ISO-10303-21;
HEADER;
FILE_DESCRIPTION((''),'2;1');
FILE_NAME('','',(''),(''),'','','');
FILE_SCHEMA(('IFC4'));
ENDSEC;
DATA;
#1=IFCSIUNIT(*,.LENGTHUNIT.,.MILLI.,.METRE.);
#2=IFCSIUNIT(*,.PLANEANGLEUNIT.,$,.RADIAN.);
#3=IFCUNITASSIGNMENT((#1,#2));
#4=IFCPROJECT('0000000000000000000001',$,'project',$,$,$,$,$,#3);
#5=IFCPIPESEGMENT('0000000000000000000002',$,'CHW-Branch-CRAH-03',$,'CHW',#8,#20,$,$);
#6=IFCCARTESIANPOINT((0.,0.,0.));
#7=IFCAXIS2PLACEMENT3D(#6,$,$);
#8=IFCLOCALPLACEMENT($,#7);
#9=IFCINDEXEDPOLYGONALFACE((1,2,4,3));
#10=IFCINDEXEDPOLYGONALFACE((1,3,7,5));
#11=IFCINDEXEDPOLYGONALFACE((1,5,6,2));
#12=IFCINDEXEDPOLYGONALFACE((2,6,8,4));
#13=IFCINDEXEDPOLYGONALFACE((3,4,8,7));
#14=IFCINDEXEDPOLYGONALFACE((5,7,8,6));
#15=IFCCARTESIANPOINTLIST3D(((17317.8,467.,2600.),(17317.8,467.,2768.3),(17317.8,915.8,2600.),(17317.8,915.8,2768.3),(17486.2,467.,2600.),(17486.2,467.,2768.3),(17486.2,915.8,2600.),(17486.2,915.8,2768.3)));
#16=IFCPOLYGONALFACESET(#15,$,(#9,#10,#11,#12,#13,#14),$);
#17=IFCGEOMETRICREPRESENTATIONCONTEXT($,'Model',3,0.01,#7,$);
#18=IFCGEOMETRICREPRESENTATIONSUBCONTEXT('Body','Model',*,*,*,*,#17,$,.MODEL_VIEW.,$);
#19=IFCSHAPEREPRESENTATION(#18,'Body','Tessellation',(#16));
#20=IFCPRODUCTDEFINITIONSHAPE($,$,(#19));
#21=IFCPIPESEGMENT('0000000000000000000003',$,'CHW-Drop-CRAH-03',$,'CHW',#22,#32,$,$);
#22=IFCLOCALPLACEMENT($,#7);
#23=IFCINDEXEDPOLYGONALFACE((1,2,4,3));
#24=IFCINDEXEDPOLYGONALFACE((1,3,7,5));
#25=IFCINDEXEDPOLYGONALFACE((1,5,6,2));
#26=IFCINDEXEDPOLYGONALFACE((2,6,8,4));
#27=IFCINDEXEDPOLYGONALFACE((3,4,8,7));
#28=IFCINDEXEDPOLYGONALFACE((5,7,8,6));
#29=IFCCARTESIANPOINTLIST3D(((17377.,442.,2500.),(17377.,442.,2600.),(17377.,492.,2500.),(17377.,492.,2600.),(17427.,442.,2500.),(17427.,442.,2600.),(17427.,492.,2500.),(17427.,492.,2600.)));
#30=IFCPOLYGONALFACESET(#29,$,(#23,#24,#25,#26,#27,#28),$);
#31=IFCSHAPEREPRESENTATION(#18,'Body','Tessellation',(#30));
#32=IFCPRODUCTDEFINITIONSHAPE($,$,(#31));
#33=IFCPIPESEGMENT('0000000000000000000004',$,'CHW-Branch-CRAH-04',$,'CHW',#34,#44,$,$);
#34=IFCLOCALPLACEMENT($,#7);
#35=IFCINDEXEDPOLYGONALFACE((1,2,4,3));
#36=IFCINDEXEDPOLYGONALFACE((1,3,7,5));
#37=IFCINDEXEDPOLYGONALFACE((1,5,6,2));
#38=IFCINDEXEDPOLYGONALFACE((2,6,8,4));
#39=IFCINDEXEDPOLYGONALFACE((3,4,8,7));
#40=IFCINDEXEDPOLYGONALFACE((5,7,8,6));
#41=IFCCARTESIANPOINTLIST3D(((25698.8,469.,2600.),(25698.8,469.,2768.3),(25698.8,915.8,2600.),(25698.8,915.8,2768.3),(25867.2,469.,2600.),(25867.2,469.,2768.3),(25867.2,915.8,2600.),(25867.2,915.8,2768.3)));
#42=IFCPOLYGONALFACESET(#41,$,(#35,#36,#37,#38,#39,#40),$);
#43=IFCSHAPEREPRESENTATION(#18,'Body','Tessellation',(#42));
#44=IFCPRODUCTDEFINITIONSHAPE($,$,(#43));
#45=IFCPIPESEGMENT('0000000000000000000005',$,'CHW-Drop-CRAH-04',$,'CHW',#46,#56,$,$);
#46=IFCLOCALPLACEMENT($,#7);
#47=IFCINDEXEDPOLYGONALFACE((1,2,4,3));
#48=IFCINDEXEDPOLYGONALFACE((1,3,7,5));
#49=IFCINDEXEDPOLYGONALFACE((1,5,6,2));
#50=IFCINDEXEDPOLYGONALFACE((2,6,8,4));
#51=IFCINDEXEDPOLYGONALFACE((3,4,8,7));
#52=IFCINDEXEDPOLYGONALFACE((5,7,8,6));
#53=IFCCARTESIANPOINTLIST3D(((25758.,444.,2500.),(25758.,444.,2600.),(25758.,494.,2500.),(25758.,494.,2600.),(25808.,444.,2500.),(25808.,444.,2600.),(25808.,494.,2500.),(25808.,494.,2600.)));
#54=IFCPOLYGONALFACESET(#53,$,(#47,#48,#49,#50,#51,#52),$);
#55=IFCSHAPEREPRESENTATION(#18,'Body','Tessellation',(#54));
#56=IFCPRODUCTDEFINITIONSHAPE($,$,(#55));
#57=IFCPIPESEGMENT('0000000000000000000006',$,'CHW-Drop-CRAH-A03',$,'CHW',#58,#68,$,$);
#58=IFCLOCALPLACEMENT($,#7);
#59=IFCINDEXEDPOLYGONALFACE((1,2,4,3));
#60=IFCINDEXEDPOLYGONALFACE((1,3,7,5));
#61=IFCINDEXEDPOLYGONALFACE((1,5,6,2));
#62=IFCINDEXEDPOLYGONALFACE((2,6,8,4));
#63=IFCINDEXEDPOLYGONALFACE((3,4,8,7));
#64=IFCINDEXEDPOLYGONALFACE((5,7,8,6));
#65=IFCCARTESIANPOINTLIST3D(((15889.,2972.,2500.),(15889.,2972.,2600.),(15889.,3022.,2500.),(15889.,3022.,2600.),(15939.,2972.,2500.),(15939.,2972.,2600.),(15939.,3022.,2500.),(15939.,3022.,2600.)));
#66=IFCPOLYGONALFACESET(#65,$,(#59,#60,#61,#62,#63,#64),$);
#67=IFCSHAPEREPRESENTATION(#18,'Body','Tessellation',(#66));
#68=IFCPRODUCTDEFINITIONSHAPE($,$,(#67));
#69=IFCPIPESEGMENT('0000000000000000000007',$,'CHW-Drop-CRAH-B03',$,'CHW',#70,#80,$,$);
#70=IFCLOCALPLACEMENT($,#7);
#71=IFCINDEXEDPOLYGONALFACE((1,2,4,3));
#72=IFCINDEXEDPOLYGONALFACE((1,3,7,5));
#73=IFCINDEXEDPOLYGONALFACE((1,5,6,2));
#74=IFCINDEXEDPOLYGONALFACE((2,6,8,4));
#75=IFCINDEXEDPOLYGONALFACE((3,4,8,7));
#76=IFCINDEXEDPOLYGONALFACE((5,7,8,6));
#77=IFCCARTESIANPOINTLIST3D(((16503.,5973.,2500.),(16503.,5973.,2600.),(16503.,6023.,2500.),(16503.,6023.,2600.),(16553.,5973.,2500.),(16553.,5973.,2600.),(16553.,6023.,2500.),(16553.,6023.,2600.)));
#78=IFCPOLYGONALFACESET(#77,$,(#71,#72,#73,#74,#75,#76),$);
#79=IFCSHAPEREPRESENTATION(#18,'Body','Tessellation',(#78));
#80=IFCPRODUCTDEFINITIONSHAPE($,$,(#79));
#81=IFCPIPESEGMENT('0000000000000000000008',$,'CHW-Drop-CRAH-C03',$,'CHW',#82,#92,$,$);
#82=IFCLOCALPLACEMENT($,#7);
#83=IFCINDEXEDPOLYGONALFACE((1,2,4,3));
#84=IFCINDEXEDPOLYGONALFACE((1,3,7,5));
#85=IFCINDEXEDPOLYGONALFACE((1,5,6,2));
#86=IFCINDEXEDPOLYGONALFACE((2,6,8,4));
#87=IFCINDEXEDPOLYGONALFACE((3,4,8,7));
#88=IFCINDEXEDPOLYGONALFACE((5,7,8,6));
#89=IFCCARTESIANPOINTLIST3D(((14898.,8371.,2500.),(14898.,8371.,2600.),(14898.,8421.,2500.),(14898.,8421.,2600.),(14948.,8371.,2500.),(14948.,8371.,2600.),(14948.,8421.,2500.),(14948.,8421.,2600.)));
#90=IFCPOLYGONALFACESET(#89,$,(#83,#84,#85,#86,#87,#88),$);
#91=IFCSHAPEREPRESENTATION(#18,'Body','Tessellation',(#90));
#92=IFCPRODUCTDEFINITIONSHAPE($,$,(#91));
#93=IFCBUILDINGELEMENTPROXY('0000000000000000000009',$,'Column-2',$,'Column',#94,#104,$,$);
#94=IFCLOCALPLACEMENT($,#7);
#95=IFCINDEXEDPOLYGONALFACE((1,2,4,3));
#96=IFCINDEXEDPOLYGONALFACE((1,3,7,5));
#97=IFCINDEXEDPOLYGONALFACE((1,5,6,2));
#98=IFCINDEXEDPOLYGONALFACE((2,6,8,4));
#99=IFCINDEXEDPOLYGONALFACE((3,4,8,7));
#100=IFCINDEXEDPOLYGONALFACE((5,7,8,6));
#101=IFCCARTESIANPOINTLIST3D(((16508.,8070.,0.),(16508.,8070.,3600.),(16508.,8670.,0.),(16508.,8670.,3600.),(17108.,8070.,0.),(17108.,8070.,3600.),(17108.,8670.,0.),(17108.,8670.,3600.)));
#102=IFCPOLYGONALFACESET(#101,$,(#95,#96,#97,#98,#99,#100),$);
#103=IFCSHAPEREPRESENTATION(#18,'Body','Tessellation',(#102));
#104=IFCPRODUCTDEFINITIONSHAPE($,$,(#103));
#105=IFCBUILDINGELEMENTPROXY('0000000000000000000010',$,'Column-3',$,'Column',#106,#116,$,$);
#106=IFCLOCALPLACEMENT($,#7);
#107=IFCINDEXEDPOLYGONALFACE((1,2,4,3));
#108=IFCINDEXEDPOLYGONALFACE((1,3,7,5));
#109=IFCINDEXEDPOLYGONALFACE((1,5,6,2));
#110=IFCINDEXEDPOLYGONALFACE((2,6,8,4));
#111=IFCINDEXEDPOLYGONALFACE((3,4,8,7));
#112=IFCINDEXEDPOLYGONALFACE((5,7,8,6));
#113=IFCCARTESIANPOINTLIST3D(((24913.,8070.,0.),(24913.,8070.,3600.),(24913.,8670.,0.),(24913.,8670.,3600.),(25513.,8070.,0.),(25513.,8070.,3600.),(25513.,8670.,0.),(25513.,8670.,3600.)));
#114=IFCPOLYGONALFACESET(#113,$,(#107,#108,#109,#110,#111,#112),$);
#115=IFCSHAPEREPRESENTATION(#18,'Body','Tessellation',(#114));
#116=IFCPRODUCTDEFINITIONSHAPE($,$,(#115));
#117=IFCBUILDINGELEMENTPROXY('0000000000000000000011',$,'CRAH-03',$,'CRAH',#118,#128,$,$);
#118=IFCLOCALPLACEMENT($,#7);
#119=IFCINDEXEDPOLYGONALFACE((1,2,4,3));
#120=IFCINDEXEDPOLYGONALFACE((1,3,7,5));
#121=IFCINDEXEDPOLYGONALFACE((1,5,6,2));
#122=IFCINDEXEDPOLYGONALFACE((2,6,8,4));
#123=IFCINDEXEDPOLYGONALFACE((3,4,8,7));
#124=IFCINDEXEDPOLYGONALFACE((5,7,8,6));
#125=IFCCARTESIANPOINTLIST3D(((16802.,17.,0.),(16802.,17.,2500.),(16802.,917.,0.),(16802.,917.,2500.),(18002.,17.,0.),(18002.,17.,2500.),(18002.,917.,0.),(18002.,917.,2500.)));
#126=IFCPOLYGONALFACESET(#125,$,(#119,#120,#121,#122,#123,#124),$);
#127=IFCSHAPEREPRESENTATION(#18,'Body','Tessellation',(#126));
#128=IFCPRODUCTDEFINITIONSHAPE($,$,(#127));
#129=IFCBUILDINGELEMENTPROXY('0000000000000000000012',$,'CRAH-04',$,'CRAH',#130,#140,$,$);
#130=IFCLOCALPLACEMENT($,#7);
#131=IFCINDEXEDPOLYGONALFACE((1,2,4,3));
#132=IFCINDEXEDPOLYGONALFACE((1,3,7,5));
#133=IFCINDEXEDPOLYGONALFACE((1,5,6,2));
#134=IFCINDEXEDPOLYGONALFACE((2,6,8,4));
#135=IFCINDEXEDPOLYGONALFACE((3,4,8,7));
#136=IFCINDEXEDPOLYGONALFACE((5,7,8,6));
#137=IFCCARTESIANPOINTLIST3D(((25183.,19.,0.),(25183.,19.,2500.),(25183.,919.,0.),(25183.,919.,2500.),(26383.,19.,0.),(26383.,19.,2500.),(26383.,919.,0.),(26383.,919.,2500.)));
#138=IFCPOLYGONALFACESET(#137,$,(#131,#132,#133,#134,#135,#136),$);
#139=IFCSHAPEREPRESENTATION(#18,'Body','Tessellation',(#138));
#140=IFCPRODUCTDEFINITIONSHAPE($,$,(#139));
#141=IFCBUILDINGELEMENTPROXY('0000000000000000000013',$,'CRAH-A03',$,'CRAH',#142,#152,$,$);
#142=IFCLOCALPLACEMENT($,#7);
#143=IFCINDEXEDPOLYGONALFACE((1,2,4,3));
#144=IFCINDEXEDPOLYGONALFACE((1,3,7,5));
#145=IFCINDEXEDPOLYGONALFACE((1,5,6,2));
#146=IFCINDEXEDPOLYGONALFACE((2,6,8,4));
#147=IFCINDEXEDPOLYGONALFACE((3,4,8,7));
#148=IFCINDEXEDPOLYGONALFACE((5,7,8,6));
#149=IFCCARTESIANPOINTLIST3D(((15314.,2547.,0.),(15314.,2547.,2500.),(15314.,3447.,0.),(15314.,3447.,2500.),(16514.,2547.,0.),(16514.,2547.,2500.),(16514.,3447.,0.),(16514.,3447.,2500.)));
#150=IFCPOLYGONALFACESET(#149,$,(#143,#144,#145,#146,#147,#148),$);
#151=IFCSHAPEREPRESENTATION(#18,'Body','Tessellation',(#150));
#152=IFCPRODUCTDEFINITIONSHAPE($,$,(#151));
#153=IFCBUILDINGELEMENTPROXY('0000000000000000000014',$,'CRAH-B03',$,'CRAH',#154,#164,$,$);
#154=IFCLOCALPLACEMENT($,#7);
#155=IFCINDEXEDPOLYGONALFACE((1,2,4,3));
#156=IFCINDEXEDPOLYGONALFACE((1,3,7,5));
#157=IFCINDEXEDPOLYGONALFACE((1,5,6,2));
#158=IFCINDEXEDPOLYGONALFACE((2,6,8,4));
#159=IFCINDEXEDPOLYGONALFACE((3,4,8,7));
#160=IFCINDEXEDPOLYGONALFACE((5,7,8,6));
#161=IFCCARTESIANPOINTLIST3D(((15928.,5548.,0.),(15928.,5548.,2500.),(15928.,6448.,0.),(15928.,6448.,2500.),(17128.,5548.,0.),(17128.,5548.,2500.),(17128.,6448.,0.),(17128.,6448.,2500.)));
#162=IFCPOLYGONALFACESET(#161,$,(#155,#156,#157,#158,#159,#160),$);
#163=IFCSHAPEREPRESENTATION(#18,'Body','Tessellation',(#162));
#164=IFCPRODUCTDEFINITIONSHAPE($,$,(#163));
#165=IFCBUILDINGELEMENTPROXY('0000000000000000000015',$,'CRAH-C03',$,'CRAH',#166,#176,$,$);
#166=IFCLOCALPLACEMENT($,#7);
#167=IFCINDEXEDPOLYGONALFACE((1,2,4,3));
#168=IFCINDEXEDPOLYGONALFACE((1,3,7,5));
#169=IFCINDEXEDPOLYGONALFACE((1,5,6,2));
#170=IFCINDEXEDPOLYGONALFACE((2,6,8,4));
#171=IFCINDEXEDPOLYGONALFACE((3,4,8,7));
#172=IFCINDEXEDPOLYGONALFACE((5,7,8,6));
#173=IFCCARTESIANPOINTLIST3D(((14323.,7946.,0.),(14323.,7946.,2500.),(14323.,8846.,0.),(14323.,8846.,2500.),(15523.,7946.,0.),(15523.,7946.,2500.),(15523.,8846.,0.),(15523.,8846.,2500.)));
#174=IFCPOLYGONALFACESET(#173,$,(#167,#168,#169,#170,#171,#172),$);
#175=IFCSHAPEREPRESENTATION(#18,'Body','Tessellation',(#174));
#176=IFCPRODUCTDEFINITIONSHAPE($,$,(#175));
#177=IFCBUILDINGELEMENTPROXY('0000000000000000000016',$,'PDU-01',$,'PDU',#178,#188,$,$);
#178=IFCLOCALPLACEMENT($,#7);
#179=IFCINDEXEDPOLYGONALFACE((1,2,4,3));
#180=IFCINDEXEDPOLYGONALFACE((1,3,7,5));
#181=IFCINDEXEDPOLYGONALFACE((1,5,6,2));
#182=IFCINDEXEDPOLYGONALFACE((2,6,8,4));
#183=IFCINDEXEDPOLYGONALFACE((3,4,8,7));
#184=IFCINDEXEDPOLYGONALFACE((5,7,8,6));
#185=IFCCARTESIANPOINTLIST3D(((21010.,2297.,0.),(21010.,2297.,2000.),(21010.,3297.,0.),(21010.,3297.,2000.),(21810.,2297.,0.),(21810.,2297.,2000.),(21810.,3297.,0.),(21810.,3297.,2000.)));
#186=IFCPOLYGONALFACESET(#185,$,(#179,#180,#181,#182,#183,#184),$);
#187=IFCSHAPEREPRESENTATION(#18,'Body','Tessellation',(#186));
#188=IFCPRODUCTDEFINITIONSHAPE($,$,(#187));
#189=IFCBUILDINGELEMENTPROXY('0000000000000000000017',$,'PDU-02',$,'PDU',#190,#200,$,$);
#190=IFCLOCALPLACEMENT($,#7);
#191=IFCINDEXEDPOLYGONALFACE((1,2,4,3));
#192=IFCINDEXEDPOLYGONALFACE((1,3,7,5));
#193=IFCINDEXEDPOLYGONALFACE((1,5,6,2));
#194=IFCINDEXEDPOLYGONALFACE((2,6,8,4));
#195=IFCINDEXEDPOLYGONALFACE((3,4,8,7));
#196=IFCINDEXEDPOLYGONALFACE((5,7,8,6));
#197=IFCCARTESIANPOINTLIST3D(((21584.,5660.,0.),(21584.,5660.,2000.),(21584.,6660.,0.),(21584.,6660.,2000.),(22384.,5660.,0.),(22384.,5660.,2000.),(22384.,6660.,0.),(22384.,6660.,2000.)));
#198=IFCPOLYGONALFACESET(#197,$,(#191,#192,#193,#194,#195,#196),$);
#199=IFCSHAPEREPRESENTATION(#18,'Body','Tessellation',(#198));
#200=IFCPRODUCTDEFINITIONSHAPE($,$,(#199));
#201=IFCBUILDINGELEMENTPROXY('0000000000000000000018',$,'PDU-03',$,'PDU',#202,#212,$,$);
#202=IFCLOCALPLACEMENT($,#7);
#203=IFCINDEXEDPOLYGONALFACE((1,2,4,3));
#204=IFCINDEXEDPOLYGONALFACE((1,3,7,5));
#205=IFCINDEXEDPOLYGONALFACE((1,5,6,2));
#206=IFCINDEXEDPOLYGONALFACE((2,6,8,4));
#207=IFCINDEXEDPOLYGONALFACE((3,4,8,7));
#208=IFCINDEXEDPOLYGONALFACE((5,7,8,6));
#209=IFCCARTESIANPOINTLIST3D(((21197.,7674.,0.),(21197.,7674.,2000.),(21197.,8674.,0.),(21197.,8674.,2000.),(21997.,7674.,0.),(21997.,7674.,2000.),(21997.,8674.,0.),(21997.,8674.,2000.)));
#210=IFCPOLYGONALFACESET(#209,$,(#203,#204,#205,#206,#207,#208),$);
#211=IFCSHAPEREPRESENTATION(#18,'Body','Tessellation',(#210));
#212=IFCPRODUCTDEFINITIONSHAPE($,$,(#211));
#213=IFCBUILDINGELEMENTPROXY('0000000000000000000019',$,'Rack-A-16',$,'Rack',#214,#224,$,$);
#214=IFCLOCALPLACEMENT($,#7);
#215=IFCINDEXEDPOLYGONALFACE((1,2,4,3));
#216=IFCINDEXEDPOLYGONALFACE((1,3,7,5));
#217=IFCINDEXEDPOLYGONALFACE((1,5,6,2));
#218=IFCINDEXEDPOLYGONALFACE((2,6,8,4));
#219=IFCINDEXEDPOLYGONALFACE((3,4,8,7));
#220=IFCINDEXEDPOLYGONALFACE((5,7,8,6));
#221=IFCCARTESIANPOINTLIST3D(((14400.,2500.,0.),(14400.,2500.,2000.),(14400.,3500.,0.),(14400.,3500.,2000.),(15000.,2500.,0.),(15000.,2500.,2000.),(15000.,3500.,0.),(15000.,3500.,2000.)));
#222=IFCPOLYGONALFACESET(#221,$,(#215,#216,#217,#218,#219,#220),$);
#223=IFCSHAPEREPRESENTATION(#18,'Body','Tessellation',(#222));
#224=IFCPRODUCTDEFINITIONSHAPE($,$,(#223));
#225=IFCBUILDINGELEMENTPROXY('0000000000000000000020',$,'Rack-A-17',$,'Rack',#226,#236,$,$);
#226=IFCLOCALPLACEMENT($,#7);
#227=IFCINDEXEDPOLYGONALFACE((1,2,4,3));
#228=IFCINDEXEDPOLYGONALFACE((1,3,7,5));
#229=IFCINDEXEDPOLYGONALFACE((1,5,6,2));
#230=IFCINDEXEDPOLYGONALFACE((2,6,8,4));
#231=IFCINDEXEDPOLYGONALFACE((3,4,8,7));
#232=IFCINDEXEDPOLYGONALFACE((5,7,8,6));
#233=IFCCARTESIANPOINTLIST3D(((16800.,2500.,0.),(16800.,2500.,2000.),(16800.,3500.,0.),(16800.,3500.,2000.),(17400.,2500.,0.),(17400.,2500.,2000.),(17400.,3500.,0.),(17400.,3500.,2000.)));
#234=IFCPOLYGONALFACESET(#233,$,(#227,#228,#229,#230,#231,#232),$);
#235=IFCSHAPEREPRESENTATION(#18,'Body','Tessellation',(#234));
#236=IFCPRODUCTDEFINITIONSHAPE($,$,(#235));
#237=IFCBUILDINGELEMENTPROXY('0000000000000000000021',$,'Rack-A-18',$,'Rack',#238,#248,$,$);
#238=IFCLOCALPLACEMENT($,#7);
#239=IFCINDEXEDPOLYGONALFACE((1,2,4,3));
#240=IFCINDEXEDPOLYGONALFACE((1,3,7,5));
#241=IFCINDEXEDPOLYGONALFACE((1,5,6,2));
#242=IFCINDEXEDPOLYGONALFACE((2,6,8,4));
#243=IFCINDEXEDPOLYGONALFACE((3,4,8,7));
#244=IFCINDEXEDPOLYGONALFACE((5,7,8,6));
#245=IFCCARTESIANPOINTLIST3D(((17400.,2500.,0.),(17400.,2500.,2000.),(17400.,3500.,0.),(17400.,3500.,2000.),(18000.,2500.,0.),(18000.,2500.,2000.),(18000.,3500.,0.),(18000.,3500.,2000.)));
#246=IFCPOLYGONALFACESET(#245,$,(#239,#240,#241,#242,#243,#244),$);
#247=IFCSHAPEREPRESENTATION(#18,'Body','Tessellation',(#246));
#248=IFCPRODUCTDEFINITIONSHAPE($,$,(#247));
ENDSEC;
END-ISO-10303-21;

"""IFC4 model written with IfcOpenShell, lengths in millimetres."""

from ifc_helpers import new_model, si_unit, frame, origin, place, context, subcontext, project, rectangle, extrude, element, save


model = new_model("IFC4")

# Units and contexts
model_context = context("Model", 3, precision=0.01, world=origin())
body_context = subcontext(model_context, "Body", "Model", "MODEL_VIEW")
ifc_project = project(units=[si_unit("LENGTHUNIT", "METRE", prefix="MILLI"), si_unit("PLANEANGLEUNIT", "RADIAN")])

# Pipe segments
placement = place(None, origin())
pipe_segment_1_placement = place(placement, frame((17402.0, 691.4, 2600.0)))
element("IfcPipeSegment", 1, at=pipe_segment_1_placement, Name="CHW-Branch-CRAH-03", ObjectType="CHW", context=body_context, shape_type="SweptSolid", body=[
    extrude(rectangle(XDim=168.3, YDim=448.9), origin(), (0.0, 0.0, 1.0), 168.3),
])
pipe_segment_2_placement = place(placement, frame((17402.0, 467.0, 2500.0)))
element("IfcPipeSegment", 2, at=pipe_segment_2_placement, Name="CHW-Drop-CRAH-03", ObjectType="CHW", context=body_context, shape_type="SweptSolid", body=[
    extrude(rectangle(XDim=50.0, YDim=50.0), origin(), (0.0, 0.0, 1.0), 100.0),
])
pipe_segment_3_placement = place(placement, frame((25783.0, 692.4, 2600.0)))
element("IfcPipeSegment", 3, at=pipe_segment_3_placement, Name="CHW-Branch-CRAH-04", ObjectType="CHW", context=body_context, shape_type="SweptSolid", body=[
    extrude(rectangle(XDim=168.3, YDim=446.9), origin(), (0.0, 0.0, 1.0), 168.3),
])
for number, where, name in (
    (4, (25783.0, 469.0, 2500.0), "CHW-Drop-CRAH-04"),
    (5, (15914.0, 2997.0, 2500.0), "CHW-Drop-CRAH-A03"),
    (6, (16528.0, 5998.0, 2500.0), "CHW-Drop-CRAH-B03"),
    (7, (14923.0, 8396.0, 2500.0), "CHW-Drop-CRAH-C03"),
):
    element("IfcPipeSegment", number, at=place(placement, frame(where)), Name=name, ObjectType="CHW", context=body_context, shape_type="SweptSolid", body=[
        extrude(rectangle(XDim=50.0, YDim=50.0), origin(), (0.0, 0.0, 1.0), 100.0),
    ])

# Building element proxies
for number, where, name in (
    (8, (16808.0, 8370.0, 0.0), "Column-2"),
    (9, (25213.0, 8370.0, 0.0), "Column-3"),
):
    element("IfcBuildingElementProxy", number, at=place(placement, frame(where)), Name=name, ObjectType="Column", context=body_context, shape_type="SweptSolid", body=[
        extrude(rectangle(XDim=600.0, YDim=600.0), origin(), (0.0, 0.0, 1.0), 3600.0),
    ])
for number, where, name in (
    (10, (17402.0, 467.0, 0.0), "CRAH-03"),
    (11, (25783.0, 469.0, 0.0), "CRAH-04"),
    (12, (15914.0, 2997.0, 0.0), "CRAH-A03"),
    (13, (16528.0, 5998.0, 0.0), "CRAH-B03"),
    (14, (14923.0, 8396.0, 0.0), "CRAH-C03"),
):
    element("IfcBuildingElementProxy", number, at=place(placement, frame(where)), Name=name, ObjectType="CRAH", context=body_context, shape_type="SweptSolid", body=[
        extrude(rectangle(XDim=1200.0, YDim=900.0), origin(), (0.0, 0.0, 1.0), 2500.0),
    ])
for number, where, name in (
    (15, (21410.0, 2797.0, 0.0), "PDU-01"),
    (16, (21984.0, 6160.0, 0.0), "PDU-02"),
    (17, (21597.0, 8174.0, 0.0), "PDU-03"),
):
    element("IfcBuildingElementProxy", number, at=place(placement, frame(where)), Name=name, ObjectType="PDU", context=body_context, shape_type="SweptSolid", body=[
        extrude(rectangle(XDim=800.0, YDim=1000.0), origin(), (0.0, 0.0, 1.0), 2000.0),
    ])
for number, where, name in (
    (18, (14700.0, 3000.0, 0.0), "Rack-A-16"),
    (19, (17100.0, 3000.0, 0.0), "Rack-A-17"),
    (20, (17700.0, 3000.0, 0.0), "Rack-A-18"),
):
    element("IfcBuildingElementProxy", number, at=place(placement, frame(where)), Name=name, ObjectType="Rack", context=body_context, shape_type="SweptSolid", body=[
        extrude(rectangle(XDim=600.0, YDim=1000.0), origin(), (0.0, 0.0, 1.0), 2000.0),
    ])

save(model, "model.ifc")
